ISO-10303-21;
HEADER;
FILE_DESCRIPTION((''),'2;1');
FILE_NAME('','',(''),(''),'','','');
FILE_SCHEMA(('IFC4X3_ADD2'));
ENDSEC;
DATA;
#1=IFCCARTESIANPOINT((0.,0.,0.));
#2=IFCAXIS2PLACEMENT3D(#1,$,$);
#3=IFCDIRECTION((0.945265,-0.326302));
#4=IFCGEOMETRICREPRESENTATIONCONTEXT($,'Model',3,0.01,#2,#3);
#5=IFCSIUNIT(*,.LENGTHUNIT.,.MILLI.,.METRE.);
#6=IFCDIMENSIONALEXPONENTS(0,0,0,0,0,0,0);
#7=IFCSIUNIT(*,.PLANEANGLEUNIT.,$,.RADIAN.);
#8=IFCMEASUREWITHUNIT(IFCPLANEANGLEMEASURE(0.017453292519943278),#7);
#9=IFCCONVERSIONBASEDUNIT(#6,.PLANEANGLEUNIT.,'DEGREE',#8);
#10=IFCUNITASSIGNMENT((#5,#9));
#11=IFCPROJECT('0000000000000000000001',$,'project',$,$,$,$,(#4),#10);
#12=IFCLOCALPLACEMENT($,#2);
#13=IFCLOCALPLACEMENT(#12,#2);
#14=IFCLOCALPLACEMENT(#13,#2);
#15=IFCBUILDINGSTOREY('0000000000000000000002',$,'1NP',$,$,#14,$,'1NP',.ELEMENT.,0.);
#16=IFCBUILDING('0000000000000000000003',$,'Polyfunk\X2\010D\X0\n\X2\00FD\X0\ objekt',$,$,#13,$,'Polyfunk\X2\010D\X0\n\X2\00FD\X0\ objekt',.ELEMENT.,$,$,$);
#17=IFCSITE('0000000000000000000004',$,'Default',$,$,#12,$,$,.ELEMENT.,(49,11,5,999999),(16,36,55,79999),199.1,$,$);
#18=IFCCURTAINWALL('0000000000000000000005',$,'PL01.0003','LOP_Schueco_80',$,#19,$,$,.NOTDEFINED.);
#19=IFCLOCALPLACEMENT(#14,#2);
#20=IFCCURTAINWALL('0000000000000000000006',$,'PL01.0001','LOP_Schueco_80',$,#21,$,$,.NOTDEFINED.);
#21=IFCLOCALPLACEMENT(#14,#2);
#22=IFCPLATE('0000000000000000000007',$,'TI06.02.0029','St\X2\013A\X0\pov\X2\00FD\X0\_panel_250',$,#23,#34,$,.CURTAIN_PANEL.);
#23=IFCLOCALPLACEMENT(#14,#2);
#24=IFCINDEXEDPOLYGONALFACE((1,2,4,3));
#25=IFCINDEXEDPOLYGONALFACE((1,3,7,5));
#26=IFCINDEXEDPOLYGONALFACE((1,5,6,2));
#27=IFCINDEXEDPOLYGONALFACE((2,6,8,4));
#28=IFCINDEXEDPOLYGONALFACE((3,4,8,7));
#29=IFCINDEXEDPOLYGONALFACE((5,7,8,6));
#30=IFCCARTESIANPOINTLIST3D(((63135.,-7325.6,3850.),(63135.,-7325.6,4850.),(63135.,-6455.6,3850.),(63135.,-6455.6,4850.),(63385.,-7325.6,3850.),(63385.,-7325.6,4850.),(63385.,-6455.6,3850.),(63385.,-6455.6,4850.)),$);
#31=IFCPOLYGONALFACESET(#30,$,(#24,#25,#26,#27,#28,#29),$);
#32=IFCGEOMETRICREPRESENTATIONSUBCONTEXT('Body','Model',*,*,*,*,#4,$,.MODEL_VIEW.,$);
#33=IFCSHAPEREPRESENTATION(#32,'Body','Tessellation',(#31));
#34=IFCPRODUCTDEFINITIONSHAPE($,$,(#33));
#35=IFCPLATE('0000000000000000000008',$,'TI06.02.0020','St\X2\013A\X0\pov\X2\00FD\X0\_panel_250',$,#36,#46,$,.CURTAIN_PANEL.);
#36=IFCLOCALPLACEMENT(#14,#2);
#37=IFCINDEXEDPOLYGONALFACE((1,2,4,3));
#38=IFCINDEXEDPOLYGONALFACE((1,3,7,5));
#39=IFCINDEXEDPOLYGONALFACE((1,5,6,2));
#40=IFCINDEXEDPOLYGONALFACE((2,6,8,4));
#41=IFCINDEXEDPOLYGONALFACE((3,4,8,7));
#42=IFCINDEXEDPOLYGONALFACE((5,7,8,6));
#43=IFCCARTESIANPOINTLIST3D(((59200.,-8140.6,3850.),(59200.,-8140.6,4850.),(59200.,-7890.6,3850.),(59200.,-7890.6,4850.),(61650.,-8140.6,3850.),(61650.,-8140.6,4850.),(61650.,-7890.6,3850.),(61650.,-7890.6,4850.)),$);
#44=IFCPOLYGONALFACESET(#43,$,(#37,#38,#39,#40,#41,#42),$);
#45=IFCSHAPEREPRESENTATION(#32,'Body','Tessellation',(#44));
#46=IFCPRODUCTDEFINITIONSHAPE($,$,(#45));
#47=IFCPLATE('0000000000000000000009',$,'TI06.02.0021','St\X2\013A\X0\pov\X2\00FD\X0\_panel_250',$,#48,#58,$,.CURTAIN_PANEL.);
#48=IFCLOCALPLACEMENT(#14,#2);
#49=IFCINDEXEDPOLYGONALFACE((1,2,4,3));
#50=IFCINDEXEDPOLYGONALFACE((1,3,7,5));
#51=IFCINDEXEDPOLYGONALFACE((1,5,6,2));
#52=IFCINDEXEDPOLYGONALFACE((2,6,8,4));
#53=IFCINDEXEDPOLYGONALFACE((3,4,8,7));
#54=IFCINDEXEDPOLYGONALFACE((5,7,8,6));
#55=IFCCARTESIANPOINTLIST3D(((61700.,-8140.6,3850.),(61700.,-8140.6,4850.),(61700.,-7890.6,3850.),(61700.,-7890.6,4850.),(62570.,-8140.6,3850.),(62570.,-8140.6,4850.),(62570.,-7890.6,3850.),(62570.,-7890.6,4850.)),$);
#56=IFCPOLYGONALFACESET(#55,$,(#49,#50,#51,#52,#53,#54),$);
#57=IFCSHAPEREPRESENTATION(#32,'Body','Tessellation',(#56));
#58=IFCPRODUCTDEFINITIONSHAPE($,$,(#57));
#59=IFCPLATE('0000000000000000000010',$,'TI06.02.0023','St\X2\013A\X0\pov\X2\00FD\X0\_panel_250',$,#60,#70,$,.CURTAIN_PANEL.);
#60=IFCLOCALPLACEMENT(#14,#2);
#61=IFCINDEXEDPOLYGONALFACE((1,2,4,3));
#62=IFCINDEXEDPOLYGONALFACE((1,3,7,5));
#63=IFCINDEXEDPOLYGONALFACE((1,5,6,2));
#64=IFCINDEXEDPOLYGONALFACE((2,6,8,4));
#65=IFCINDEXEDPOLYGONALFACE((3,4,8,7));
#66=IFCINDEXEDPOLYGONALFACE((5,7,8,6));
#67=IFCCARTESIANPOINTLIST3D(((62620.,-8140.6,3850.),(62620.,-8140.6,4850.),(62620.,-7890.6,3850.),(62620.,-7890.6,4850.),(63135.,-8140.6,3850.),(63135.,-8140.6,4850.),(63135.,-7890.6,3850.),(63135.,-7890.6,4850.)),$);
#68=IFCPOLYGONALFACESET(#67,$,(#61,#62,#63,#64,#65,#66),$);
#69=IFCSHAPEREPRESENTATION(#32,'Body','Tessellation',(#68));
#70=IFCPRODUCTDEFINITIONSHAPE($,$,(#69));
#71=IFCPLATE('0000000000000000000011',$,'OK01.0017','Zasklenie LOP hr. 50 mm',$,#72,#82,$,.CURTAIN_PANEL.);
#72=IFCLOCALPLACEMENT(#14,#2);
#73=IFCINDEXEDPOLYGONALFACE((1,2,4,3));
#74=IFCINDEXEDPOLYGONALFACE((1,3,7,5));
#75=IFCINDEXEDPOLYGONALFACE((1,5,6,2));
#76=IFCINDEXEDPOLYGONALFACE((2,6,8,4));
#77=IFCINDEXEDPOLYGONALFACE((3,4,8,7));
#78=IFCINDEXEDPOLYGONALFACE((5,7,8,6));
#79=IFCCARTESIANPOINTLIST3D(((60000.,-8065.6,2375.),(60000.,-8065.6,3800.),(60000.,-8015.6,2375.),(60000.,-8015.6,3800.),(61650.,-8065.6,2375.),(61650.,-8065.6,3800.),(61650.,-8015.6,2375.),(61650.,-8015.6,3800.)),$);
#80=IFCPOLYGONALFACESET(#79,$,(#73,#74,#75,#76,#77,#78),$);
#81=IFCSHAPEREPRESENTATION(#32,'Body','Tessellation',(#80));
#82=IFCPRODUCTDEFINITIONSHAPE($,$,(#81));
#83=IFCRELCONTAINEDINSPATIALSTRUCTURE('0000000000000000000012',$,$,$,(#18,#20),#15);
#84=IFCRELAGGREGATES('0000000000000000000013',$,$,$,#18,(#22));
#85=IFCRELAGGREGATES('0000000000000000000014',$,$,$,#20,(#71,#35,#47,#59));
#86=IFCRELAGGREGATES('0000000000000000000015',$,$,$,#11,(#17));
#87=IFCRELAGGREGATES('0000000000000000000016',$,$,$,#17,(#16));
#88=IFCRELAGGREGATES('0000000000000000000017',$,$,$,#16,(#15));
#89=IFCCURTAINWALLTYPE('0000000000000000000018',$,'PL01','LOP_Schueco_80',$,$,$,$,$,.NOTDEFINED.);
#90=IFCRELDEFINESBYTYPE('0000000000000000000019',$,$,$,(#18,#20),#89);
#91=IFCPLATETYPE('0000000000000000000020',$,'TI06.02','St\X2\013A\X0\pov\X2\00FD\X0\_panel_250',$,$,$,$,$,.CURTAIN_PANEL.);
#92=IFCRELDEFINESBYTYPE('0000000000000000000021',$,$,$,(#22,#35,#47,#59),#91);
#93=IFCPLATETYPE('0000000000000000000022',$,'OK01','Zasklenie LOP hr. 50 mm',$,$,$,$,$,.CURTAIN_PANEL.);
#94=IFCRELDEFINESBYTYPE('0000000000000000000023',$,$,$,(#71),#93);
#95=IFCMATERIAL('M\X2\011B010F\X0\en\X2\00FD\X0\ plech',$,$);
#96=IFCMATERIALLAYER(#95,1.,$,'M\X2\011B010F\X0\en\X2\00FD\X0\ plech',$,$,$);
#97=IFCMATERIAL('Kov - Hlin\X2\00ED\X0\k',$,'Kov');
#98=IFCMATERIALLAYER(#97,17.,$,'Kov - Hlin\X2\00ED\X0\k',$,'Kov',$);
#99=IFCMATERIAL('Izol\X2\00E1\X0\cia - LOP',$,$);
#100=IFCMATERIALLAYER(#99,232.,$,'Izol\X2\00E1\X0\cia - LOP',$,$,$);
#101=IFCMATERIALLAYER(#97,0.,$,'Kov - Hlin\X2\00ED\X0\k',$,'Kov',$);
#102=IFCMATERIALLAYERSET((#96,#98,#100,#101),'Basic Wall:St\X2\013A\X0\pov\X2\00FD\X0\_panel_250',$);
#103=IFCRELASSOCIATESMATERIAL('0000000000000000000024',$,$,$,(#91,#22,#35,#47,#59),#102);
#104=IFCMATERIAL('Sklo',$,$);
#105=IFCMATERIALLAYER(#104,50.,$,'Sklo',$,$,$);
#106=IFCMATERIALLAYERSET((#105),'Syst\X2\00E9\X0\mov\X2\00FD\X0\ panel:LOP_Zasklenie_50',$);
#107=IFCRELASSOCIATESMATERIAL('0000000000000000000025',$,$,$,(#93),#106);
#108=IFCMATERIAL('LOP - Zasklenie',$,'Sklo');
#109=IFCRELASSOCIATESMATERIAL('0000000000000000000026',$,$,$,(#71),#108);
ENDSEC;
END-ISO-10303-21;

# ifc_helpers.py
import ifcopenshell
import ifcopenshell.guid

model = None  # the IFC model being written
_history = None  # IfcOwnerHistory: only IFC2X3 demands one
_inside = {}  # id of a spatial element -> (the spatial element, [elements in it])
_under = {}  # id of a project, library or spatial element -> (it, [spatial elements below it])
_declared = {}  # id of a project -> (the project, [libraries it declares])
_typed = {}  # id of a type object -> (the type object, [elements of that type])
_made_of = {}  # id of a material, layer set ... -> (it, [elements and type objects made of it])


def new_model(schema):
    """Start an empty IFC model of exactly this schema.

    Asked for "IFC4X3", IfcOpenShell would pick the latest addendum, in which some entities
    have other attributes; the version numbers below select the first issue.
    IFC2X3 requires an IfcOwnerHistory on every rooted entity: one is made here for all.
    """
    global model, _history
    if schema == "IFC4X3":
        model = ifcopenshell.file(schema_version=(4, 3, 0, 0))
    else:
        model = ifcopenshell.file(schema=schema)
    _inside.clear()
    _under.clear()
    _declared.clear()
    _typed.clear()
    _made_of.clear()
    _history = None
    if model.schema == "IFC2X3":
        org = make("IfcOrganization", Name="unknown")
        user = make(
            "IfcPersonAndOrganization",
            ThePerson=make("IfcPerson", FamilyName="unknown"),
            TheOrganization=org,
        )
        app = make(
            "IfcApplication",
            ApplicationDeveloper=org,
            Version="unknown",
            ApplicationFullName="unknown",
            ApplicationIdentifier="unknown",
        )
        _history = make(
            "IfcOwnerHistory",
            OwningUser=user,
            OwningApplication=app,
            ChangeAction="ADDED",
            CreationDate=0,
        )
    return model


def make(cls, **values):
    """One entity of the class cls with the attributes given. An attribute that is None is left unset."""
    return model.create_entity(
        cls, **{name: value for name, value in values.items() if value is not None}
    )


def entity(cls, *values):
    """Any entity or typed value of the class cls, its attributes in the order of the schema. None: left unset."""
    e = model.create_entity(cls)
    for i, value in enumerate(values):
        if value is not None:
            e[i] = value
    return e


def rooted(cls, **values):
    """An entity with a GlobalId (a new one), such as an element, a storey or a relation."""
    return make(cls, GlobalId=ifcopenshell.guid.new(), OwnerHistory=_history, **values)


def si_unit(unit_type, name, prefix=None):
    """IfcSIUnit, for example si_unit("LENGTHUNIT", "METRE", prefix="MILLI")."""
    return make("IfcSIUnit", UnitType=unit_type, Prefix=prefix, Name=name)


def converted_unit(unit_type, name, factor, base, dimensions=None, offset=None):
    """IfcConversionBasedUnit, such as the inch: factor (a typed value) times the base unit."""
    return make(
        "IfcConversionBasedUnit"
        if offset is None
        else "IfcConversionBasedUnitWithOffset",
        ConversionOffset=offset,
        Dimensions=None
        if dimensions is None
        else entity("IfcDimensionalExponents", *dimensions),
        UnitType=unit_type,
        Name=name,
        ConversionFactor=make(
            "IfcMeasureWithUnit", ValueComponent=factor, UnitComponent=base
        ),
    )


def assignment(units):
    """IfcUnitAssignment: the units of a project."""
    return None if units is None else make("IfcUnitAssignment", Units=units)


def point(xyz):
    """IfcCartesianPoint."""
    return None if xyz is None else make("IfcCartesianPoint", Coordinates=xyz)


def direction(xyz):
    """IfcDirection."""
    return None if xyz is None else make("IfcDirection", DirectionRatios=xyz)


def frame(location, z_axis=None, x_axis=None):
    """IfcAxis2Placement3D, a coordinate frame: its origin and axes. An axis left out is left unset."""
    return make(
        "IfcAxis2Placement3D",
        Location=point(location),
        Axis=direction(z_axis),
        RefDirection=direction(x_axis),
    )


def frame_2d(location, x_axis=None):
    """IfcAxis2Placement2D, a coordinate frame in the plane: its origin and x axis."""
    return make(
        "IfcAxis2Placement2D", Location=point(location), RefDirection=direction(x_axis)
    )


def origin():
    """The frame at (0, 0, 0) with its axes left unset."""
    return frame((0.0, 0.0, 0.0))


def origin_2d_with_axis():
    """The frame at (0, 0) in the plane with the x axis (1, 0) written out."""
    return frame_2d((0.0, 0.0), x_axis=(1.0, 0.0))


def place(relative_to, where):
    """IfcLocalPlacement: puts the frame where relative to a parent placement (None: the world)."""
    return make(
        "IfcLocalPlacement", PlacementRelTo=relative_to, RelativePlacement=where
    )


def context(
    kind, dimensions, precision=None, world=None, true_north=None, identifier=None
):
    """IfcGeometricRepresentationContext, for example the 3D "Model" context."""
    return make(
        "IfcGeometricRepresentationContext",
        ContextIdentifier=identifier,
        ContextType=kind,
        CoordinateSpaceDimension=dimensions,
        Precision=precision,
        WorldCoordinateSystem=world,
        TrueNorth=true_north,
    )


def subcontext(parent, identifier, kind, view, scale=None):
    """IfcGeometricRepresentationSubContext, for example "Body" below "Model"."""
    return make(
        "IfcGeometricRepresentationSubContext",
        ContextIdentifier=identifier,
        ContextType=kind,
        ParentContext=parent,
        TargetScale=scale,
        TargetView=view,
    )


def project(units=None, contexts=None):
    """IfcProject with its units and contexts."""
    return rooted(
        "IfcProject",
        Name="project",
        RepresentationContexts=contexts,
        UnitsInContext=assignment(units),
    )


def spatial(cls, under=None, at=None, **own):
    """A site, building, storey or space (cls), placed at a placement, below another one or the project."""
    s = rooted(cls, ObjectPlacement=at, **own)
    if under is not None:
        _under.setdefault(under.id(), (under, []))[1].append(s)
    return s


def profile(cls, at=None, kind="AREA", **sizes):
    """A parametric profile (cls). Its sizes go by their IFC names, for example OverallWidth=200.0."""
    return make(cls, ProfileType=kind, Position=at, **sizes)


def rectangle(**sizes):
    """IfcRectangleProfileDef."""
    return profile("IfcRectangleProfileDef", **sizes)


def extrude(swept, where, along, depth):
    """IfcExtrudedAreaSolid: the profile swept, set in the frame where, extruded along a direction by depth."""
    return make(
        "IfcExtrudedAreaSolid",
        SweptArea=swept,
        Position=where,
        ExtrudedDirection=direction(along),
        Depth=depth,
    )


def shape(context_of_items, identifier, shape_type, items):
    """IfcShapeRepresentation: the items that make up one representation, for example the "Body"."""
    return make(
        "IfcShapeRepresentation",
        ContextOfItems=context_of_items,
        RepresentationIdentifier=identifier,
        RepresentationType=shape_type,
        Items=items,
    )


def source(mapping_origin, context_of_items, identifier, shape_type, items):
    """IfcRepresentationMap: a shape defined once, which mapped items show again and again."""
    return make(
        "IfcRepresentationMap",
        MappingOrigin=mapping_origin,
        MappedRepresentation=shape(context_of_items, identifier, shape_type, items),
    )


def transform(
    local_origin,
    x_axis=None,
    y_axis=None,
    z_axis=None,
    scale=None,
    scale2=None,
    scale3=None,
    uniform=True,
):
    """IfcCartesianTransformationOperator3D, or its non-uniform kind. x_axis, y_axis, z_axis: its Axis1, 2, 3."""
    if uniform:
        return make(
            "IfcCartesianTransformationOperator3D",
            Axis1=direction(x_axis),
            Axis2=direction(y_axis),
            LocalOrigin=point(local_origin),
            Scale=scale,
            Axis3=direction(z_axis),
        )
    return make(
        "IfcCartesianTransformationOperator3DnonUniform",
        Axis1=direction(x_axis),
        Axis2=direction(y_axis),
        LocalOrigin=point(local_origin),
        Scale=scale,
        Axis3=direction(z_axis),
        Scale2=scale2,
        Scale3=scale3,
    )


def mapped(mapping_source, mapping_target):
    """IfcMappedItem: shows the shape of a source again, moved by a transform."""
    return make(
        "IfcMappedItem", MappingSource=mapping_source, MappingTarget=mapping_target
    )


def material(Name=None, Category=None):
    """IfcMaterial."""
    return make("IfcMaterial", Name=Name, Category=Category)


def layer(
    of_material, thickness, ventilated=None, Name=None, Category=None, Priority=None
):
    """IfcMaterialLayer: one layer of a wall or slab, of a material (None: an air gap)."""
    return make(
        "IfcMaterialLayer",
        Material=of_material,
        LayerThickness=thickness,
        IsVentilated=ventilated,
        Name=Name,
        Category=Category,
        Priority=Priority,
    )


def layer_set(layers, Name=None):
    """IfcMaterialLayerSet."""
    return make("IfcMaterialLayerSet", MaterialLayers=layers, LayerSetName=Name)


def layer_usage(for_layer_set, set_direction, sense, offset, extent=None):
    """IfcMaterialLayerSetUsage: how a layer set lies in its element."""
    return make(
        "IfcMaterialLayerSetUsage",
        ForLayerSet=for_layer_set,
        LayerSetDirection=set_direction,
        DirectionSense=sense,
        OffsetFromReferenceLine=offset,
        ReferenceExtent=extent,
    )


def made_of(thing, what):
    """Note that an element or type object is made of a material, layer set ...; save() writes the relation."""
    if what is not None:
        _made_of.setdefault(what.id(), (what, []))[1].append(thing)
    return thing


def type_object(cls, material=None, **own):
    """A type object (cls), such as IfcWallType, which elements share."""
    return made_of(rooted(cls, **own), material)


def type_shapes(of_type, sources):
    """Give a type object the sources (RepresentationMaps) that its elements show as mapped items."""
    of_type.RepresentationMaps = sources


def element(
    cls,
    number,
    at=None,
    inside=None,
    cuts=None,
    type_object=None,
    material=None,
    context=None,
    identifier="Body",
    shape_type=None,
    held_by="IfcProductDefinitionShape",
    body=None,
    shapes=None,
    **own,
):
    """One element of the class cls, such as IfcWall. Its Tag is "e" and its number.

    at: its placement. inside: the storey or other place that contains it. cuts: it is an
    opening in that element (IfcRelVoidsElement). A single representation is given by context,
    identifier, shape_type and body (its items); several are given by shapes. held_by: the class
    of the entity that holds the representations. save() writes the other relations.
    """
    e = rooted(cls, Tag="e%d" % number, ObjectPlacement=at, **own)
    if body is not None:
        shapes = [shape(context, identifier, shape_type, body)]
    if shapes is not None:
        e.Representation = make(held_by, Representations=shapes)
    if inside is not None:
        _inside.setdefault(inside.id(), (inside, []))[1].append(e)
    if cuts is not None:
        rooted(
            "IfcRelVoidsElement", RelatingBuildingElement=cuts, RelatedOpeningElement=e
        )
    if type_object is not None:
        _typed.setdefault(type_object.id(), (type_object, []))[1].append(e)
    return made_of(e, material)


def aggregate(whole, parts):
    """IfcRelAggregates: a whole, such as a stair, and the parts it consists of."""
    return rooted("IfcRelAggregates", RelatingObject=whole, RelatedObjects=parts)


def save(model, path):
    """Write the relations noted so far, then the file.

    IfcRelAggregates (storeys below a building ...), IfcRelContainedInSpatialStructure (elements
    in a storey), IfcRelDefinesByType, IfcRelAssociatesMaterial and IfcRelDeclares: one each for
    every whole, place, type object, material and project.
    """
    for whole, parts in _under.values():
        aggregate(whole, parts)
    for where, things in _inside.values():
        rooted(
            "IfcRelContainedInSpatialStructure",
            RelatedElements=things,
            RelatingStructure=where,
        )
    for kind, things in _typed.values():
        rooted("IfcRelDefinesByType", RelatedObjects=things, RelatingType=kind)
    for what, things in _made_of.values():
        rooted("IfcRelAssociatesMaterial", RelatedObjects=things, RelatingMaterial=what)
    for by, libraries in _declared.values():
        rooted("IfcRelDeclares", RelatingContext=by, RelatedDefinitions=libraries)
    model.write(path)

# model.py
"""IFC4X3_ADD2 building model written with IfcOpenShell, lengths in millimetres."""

from ifc_helpers import new_model, entity, si_unit, converted_unit, direction, frame, frame_2d, origin, origin_2d_with_axis, place, context, subcontext, project, spatial, rectangle, extrude, source, transform, mapped, material, layer, layer_set, layer_usage, type_object, type_shapes, element, aggregate, save


model = new_model("IFC4X3_ADD2")

# Units and contexts
model_context = context("Model", 3, precision=0.01, world=origin(), true_north=direction((0.945265, -0.326302)))
body_context = subcontext(model_context, "Body", "Model", "MODEL_VIEW")
ifc_project = project(units=[si_unit("LENGTHUNIT", "METRE", prefix="MILLI"), converted_unit("PLANEANGLEUNIT", "DEGREE", entity("IfcPlaneAngleMeasure", 0.017453292519943278), si_unit("PLANEANGLEUNIT", "RADIAN"), dimensions=[0, 0, 0, 0, 0, 0, 0])], contexts=[model_context])

# Site, building, storey
site_placement = place(None, origin())
site = spatial("IfcSite", under=ifc_project, at=site_placement, Name="Default", CompositionType="ELEMENT", RefLatitude=(49, 11, 5, 999999), RefLongitude=(16, 36, 55, 79999), RefElevation=199.1)
building_placement = place(site_placement, origin())
building = spatial("IfcBuilding", under=site, at=building_placement, Name="Polyfunkčný objekt", LongName="Polyfunkčný objekt", CompositionType="ELEMENT")
storey_placement = place(building_placement, origin())
storey = spatial("IfcBuildingStorey", under=building, at=storey_placement, Name="1NP", LongName="1NP", CompositionType="ELEMENT", Elevation=0.0)

# Curtain walls
curtain_wall_type = type_object("IfcCurtainWallType", Name="PL01", Description="LOP_Schueco_80", PredefinedType="NOTDEFINED")
curtain_wall_1_placement = place(storey_placement, origin())
curtain_wall_1 = element("IfcCurtainWall", 1, at=curtain_wall_1_placement, inside=storey, type_object=curtain_wall_type, Name="PL01.0003", Description="LOP_Schueco_80", PredefinedType="NOTDEFINED")
curtain_wall_2_placement = place(storey_placement, origin())
curtain_wall_2 = element("IfcCurtainWall", 2, at=curtain_wall_2_placement, inside=storey, type_object=curtain_wall_type, Name="PL01.0001", Description="LOP_Schueco_80", PredefinedType="NOTDEFINED")

# Plates
ifc_material_1 = material(Name="Měďený plech")
ifc_layer_1 = layer(ifc_material_1, 1.0, Name="Měďený plech")
ifc_material_2 = material(Name="Kov - Hliník", Category="Kov")
ifc_layer_2 = layer(ifc_material_2, 17.0, Name="Kov - Hliník", Category="Kov")
ifc_material_3 = material(Name="Izolácia - LOP")
ifc_layer_3 = layer(ifc_material_3, 232.0, Name="Izolácia - LOP")
ifc_layer_4 = layer(ifc_material_2, 0.0, Name="Kov - Hliník", Category="Kov")
ifc_layer_set_1 = layer_set([ifc_layer_1, ifc_layer_2, ifc_layer_3, ifc_layer_4], Name="Basic Wall:Stĺpový_panel_250")
ifc_layer_usage_1 = layer_usage(ifc_layer_set_1, "AXIS2", "NEGATIVE", 125.0)
plate_type_1 = type_object("IfcPlateType", Name="TI06.02", Description="Stĺpový_panel_250", PredefinedType="CURTAIN_PANEL", material=ifc_layer_set_1)
plate_1_placement = place(storey_placement, frame((63260.0, -6455.6, 3850.0), z_axis=(0.0, 0.0, 1.0), x_axis=(0.0, -1.0, 0.0)))
plate_1 = element("IfcPlate", 3, at=plate_1_placement, type_object=plate_type_1, material=ifc_layer_usage_1, Name="TI06.02.0029", Description="Stĺpový_panel_250", PredefinedType="CURTAIN_PANEL", context=body_context, shape_type="SweptSolid", body=[
    extrude(rectangle(XDim=250.0, YDim=870.0, at=frame_2d((0.0, 0.0), x_axis=(1.0, 0.0))), frame((435.0, 0.0, 0.0), z_axis=(0.0, 0.0, 1.0), x_axis=(0.0, 1.0, 0.0)), (0.0, 0.0, 1.0), 1000.0),
])
aggregate(curtain_wall_1, [plate_1])
ifc_layer_usage_2 = layer_usage(ifc_layer_set_1, "AXIS2", "POSITIVE", -125.0)
plate_2_placement = place(storey_placement, frame((59200.0, -8015.6, 3850.0)))
plate_2 = element("IfcPlate", 4, at=plate_2_placement, type_object=plate_type_1, material=ifc_layer_usage_2, Name="TI06.02.0020", Description="Stĺpový_panel_250", PredefinedType="CURTAIN_PANEL", context=body_context, shape_type="SweptSolid", body=[
    extrude(rectangle(XDim=250.0, YDim=2450.0, at=origin_2d_with_axis()), frame((1225.0, 0.0, 0.0), z_axis=(0.0, 0.0, 1.0), x_axis=(0.0, 1.0, 0.0)), (0.0, 0.0, 1.0), 1000.0),
])
ifc_layer_usage_3 = layer_usage(ifc_layer_set_1, "AXIS2", "POSITIVE", -125.0)
plate_3_placement = place(storey_placement, frame((61700.0, -8015.6, 3850.0)))
plate_3 = element("IfcPlate", 5, at=plate_3_placement, type_object=plate_type_1, material=ifc_layer_usage_3, Name="TI06.02.0021", Description="Stĺpový_panel_250", PredefinedType="CURTAIN_PANEL", context=body_context, shape_type="SweptSolid", body=[
    extrude(rectangle(XDim=250.0, YDim=870.0, at=frame_2d((0.0, 0.0), x_axis=(1.0, 0.0))), frame((435.0, 0.0, 0.0), z_axis=(0.0, 0.0, 1.0), x_axis=(0.0, 1.0, 0.0)), (0.0, 0.0, 1.0), 1000.0),
])
ifc_layer_usage_4 = layer_usage(ifc_layer_set_1, "AXIS2", "POSITIVE", -125.0)
plate_4_placement = place(storey_placement, frame((62620.0, -8015.6, 3850.0)))
plate_4 = element("IfcPlate", 6, at=plate_4_placement, type_object=plate_type_1, material=ifc_layer_usage_4, Name="TI06.02.0023", Description="Stĺpový_panel_250", PredefinedType="CURTAIN_PANEL", context=body_context, shape_type="SweptSolid", body=[
    extrude(rectangle(XDim=250.0, YDim=515.0, at=origin_2d_with_axis()), frame((257.5, 0.0, 0.0), z_axis=(0.0, 0.0, 1.0), x_axis=(0.0, 1.0, 0.0)), (0.0, 0.0, 1.0), 1000.0),
])
ifc_material_4 = material(Name="LOP - Zasklenie", Category="Sklo")
ifc_material_5 = material(Name="Sklo")
ifc_layer_5 = layer(ifc_material_5, 50.0, Name="Sklo")
ifc_layer_set_2 = layer_set([ifc_layer_5], Name="Systémový panel:LOP_Zasklenie_50")
plate_type_2 = type_object("IfcPlateType", Name="OK01", Description="Zasklenie LOP hr. 50 mm", PredefinedType="CURTAIN_PANEL", material=ifc_layer_set_2)
shared_shape_1 = source(origin(), body_context, "Body", "SweptSolid", [
    extrude(rectangle(XDim=1425.0, YDim=1650.0, at=frame_2d((87.6, 0.0), x_axis=(1.0, 0.0))), frame((0.0, -50.0, 624.9), z_axis=(0.0, 1.0, 0.0), x_axis=(0.0, 0.0, 1.0)), (0.0, 0.0, 1.0), 50.0),
])
type_shapes(plate_type_2, [shared_shape_1])
plate_5_placement = place(curtain_wall_2_placement, frame((60825.0, -8015.6, 2375.0)))
plate_5 = element("IfcPlate", 7, at=plate_5_placement, type_object=plate_type_2, material=ifc_material_4, Name="OK01.0017", Description="Zasklenie LOP hr. 50 mm", PredefinedType="CURTAIN_PANEL", context=body_context, shape_type="MappedRepresentation", body=[
    mapped(shared_shape_1, transform((0.0, 0.0, 0.0), scale=1.0)),
])
aggregate(curtain_wall_2, [plate_5, plate_2, plate_3, plate_4])

save(model, "model.ifc")
